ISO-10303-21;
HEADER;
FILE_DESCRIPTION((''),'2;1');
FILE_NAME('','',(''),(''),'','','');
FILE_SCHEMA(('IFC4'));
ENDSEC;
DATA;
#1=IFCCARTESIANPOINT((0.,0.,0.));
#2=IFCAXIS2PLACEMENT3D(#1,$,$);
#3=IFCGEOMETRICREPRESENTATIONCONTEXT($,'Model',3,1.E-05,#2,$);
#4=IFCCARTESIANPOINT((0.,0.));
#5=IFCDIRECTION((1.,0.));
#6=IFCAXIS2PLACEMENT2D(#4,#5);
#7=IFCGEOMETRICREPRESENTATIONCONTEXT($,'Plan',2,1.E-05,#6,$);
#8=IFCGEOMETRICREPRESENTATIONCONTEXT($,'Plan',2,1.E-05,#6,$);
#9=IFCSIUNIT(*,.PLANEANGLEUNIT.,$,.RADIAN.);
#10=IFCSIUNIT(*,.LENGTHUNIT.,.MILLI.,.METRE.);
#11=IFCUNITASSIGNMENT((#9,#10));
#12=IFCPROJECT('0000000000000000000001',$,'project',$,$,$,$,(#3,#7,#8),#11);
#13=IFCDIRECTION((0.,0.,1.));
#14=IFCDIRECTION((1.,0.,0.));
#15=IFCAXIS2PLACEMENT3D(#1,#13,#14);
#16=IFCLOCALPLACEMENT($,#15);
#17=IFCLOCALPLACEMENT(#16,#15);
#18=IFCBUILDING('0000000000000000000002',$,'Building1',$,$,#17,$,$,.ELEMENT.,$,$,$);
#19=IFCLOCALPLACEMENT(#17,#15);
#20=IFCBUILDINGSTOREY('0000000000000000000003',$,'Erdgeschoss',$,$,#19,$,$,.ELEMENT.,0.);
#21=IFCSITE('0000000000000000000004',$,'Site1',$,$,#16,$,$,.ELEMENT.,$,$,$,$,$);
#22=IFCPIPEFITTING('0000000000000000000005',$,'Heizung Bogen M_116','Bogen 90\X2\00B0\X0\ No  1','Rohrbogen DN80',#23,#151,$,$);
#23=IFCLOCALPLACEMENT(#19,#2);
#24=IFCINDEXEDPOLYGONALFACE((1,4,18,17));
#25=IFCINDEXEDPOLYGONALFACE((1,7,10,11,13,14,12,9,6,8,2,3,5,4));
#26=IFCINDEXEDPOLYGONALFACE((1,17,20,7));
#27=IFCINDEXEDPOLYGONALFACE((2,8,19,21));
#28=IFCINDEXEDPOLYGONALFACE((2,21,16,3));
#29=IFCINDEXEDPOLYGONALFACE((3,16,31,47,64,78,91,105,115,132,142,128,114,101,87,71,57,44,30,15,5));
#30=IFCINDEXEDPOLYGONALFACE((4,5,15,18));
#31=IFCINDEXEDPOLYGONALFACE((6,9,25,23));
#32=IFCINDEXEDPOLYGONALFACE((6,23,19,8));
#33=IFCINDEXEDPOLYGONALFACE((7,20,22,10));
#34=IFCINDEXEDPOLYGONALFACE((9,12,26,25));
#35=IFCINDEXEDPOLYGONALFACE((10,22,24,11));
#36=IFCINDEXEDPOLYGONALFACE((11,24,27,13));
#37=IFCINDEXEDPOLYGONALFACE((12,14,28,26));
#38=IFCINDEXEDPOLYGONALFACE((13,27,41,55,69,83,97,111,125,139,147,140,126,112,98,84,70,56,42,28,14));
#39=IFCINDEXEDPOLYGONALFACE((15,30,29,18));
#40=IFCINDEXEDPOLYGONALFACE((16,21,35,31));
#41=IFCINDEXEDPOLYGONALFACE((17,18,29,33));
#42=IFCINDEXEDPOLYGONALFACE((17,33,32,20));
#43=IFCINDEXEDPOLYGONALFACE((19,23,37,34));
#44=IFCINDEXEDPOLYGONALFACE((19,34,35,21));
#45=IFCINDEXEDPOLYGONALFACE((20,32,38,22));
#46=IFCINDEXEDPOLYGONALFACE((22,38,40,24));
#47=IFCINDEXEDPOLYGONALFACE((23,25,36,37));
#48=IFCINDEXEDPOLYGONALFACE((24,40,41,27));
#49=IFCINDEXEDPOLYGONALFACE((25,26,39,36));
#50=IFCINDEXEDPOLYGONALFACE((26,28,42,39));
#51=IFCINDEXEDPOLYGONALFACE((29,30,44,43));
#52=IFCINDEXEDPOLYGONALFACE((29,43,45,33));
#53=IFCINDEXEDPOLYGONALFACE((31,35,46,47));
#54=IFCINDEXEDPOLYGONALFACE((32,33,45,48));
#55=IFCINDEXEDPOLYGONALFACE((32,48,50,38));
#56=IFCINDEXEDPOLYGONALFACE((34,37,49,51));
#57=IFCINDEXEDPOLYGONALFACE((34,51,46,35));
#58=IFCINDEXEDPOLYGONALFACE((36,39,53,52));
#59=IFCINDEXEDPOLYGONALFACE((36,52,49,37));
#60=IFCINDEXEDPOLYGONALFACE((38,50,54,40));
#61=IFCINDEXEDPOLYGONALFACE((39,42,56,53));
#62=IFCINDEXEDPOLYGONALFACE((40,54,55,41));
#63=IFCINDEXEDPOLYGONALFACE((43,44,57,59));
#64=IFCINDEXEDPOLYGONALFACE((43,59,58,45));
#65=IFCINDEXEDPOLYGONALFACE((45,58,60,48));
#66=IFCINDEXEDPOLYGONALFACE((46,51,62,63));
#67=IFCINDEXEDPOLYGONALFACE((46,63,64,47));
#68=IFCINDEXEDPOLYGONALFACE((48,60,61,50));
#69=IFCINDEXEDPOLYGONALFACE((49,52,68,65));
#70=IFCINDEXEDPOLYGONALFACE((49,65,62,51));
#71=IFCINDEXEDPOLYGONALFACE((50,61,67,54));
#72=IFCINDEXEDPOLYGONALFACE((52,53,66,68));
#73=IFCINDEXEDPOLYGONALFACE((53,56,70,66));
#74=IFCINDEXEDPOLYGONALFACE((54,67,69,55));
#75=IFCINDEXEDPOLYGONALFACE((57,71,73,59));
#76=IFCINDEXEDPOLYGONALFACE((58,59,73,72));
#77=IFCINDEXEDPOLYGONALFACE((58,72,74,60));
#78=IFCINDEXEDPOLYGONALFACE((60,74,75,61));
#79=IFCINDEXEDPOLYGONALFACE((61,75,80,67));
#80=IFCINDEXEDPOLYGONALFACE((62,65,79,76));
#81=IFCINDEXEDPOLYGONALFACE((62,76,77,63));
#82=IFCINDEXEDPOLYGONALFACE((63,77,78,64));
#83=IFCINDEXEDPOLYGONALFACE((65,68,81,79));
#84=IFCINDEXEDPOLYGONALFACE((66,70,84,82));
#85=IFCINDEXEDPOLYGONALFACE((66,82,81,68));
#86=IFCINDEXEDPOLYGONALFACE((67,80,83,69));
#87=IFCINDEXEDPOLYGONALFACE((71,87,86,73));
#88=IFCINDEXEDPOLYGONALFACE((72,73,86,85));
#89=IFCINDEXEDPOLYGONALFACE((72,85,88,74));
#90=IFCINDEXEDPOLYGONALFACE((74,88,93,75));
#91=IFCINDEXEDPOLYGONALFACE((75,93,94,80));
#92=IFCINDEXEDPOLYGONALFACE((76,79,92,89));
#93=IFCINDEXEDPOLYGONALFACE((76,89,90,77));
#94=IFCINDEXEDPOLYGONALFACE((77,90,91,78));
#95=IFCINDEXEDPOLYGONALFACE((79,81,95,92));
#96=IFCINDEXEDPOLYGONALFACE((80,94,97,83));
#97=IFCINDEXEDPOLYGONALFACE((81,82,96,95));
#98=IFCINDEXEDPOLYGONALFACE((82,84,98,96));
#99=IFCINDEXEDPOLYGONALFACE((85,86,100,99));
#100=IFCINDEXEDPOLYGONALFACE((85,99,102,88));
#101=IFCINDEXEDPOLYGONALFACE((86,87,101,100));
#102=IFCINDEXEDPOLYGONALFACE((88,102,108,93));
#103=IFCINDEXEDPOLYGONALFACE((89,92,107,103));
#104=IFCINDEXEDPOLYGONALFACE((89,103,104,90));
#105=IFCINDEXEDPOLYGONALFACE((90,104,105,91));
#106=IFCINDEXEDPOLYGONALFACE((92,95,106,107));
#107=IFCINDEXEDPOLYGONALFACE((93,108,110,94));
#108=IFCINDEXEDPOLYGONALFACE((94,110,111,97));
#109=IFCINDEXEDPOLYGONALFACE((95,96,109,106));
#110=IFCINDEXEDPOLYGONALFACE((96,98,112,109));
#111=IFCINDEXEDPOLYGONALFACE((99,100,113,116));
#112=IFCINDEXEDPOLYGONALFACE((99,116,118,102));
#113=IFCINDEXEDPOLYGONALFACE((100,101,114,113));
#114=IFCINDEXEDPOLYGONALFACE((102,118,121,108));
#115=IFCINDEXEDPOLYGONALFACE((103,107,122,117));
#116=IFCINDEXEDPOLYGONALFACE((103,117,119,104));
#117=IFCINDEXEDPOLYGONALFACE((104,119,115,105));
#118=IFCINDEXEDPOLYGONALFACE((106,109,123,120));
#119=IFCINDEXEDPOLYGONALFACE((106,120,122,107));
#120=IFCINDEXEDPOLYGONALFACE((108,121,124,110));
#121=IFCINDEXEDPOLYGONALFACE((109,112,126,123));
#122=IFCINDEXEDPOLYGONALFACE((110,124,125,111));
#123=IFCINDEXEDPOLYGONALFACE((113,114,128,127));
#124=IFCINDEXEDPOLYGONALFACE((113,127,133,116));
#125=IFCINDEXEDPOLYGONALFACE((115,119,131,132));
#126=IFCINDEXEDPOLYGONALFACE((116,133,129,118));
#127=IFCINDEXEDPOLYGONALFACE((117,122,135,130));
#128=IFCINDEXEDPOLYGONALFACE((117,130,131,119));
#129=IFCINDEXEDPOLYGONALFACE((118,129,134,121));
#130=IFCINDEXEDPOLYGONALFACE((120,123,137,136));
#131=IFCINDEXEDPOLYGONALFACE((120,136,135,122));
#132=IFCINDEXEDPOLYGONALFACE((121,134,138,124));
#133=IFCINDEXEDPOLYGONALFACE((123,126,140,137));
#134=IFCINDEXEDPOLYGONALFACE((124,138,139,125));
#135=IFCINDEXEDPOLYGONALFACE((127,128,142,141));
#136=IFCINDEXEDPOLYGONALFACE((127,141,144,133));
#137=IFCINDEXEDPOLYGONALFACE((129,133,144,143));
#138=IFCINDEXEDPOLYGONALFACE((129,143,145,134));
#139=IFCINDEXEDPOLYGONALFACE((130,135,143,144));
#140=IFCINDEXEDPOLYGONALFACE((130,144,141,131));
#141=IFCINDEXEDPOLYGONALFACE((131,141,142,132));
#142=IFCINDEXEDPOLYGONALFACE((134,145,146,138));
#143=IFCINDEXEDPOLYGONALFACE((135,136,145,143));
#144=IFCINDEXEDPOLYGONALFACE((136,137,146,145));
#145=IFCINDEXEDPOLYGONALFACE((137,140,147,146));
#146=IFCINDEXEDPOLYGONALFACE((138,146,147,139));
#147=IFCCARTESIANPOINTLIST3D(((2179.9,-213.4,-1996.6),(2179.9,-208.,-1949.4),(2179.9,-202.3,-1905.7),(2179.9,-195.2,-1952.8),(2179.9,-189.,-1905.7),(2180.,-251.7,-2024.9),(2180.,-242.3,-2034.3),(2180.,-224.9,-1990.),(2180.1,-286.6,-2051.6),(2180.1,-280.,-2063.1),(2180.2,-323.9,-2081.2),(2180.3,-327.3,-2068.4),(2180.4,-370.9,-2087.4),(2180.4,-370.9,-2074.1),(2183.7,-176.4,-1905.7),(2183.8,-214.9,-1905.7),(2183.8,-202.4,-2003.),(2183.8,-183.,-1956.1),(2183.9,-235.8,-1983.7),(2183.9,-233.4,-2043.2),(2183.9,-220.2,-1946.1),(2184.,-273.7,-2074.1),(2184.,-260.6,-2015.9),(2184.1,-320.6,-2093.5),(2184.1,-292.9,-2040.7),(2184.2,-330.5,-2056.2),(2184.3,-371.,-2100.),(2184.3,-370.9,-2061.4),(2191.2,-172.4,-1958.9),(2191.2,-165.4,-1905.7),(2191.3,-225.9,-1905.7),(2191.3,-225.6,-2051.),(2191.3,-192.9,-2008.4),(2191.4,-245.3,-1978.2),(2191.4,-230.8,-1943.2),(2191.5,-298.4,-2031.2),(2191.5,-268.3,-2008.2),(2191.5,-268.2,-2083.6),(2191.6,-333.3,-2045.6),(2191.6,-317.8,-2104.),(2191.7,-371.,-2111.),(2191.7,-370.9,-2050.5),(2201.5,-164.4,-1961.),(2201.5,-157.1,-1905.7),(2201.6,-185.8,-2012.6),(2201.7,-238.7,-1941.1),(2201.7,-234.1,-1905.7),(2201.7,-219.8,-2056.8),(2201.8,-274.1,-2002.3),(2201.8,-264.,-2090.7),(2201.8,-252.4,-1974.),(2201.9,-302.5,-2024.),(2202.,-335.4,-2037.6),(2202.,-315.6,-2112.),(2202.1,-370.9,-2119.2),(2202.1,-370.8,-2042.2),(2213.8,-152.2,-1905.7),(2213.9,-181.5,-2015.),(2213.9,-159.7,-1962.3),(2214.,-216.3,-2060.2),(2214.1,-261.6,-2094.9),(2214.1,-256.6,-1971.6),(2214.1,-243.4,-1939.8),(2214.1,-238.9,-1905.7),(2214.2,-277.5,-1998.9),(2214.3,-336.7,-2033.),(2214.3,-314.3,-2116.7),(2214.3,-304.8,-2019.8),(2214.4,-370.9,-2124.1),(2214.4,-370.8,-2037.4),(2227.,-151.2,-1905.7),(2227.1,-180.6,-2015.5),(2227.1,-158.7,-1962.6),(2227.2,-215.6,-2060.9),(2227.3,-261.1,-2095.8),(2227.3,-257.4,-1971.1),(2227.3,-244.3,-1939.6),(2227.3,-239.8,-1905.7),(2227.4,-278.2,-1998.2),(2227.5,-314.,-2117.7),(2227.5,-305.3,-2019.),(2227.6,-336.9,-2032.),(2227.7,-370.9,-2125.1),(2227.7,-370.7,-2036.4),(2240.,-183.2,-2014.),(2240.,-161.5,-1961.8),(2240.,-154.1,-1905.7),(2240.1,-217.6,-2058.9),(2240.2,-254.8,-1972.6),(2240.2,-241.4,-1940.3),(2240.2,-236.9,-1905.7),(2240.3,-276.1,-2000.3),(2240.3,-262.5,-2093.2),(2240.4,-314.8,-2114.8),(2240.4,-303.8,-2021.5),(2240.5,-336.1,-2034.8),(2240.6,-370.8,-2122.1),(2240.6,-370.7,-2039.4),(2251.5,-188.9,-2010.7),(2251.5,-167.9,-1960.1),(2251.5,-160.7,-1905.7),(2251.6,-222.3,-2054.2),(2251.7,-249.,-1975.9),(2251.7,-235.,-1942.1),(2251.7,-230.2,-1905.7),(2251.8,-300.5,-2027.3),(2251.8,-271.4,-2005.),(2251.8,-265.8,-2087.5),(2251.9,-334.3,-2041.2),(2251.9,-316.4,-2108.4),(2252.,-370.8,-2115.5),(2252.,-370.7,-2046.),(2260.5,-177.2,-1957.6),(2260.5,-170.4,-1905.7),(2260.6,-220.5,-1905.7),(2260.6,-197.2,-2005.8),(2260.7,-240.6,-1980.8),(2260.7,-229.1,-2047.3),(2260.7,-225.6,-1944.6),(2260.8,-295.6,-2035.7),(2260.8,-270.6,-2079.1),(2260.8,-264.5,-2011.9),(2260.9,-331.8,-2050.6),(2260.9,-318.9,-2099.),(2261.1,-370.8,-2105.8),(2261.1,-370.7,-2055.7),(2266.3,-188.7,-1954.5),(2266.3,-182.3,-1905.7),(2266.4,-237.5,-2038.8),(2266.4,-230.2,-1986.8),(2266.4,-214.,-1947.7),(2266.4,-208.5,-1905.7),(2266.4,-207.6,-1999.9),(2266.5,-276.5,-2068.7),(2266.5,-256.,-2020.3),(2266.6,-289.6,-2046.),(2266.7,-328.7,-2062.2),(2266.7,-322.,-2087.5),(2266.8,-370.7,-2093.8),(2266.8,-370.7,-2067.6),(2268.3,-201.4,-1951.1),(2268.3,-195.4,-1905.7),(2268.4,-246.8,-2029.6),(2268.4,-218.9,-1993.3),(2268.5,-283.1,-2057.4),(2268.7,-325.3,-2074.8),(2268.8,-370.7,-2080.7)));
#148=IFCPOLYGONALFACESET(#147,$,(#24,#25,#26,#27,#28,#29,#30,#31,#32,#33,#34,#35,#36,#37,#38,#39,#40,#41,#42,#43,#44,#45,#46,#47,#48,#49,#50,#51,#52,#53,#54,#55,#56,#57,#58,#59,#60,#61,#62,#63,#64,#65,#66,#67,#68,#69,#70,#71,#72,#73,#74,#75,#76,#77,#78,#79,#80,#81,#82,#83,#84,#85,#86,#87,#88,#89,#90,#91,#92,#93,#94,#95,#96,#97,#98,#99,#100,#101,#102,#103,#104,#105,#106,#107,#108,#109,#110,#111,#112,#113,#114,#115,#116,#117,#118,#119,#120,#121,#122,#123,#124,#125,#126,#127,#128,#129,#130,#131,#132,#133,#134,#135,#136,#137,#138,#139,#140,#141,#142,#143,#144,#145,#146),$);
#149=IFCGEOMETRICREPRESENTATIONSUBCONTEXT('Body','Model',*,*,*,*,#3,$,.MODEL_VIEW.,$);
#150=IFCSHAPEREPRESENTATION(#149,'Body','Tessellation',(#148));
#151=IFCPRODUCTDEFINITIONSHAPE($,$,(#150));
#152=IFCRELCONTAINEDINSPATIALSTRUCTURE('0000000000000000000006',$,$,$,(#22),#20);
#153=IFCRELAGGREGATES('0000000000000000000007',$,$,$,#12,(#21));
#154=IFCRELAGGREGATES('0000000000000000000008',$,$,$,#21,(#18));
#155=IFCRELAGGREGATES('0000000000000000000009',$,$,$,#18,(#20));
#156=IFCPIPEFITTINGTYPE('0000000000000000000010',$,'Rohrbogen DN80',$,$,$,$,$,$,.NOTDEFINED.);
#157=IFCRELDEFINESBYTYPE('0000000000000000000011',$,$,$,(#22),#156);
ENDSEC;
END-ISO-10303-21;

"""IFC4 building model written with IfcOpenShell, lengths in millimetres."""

from ifc_helpers import new_model, entity, si_unit, frame, origin, origin_with_axes, origin_2d_with_axis, place, context, subcontext, project, spatial, source, transform, mapped, type_object, element, save


model = new_model("IFC4")

# Units and contexts
model_context = context("Model", 3, precision=1e-05, world=origin())
plan_context_1 = context("Plan", 2, precision=1e-05, world=origin_2d_with_axis())
plan_context_2 = context("Plan", 2, precision=1e-05, world=origin_2d_with_axis())
body_context = subcontext(model_context, "Body", "Model", "MODEL_VIEW")
ifc_project = project(units=[si_unit("PLANEANGLEUNIT", "RADIAN"), si_unit("LENGTHUNIT", "METRE", prefix="MILLI")], contexts=[model_context, plan_context_1, plan_context_2])

# Site, building, storey
site_placement = place(None, origin_with_axes())
site = spatial("IfcSite", under=ifc_project, at=site_placement, Name="Site1", CompositionType="ELEMENT")
building_placement = place(site_placement, origin_with_axes())
building = spatial("IfcBuilding", under=site, at=building_placement, Name="Building1", CompositionType="ELEMENT")
storey_placement = place(building_placement, origin_with_axes())
storey = spatial("IfcBuildingStorey", under=building, at=storey_placement, Name="Erdgeschoss", CompositionType="ELEMENT", Elevation=0.0)

# Pipe fitting
pipe_fitting_type_1 = type_object("IfcPipeFittingType", Name="Rohrbogen DN80", PredefinedType="NOTDEFINED")
shared_shape_1 = source(origin_with_axes(), body_context, "Body", "SolidModel", [
    entity("IfcRevolvedAreaSolid", entity("IfcCircleProfileDef", "AREA", None, entity("IfcAxis2Placement2D", entity("IfcCartesianPoint", [0.0, 0.0]), entity("IfcDirection", [1.0, 0.0])), 44.5), entity("IfcAxis2Placement3D", entity("IfcCartesianPoint", [109.7, -0.2, 65.5]), entity("IfcDirection", [-1.0, 0.0, 0.0]), entity("IfcDirection", [0.0, 0.999996, 0.002779])), entity("IfcAxis1Placement", entity("IfcCartesianPoint", [0.0, 175.0, 0.0]), entity("IfcDirection", [-1.0, 0.0, 0.0])), 1.572437),
])
pipe_fitting_1_placement = place(storey_placement, frame((2224.0, -261.0, -2015.5), z_axis=(0.0, 0.0, 1.0), x_axis=(1.0, 0.0, 0.0)))
element("IfcPipeFitting", 1, at=pipe_fitting_1_placement, inside=storey, type_object=pipe_fitting_type_1, Name="Heizung Bogen M_116", Description="Bogen 90° No  1", ObjectType="Rohrbogen DN80", context=body_context, shape_type="MappedRepresentation", body=[
    mapped(shared_shape_1, transform((0.0, 0.0, 0.0), x_axis=(0.0, 0.0, 1.0), y_axis=(1.0, 0.0, 0.0), z_axis=(0.0, 1.0, 0.0), scale=1.0)),
])

save(model, "model.ifc")
